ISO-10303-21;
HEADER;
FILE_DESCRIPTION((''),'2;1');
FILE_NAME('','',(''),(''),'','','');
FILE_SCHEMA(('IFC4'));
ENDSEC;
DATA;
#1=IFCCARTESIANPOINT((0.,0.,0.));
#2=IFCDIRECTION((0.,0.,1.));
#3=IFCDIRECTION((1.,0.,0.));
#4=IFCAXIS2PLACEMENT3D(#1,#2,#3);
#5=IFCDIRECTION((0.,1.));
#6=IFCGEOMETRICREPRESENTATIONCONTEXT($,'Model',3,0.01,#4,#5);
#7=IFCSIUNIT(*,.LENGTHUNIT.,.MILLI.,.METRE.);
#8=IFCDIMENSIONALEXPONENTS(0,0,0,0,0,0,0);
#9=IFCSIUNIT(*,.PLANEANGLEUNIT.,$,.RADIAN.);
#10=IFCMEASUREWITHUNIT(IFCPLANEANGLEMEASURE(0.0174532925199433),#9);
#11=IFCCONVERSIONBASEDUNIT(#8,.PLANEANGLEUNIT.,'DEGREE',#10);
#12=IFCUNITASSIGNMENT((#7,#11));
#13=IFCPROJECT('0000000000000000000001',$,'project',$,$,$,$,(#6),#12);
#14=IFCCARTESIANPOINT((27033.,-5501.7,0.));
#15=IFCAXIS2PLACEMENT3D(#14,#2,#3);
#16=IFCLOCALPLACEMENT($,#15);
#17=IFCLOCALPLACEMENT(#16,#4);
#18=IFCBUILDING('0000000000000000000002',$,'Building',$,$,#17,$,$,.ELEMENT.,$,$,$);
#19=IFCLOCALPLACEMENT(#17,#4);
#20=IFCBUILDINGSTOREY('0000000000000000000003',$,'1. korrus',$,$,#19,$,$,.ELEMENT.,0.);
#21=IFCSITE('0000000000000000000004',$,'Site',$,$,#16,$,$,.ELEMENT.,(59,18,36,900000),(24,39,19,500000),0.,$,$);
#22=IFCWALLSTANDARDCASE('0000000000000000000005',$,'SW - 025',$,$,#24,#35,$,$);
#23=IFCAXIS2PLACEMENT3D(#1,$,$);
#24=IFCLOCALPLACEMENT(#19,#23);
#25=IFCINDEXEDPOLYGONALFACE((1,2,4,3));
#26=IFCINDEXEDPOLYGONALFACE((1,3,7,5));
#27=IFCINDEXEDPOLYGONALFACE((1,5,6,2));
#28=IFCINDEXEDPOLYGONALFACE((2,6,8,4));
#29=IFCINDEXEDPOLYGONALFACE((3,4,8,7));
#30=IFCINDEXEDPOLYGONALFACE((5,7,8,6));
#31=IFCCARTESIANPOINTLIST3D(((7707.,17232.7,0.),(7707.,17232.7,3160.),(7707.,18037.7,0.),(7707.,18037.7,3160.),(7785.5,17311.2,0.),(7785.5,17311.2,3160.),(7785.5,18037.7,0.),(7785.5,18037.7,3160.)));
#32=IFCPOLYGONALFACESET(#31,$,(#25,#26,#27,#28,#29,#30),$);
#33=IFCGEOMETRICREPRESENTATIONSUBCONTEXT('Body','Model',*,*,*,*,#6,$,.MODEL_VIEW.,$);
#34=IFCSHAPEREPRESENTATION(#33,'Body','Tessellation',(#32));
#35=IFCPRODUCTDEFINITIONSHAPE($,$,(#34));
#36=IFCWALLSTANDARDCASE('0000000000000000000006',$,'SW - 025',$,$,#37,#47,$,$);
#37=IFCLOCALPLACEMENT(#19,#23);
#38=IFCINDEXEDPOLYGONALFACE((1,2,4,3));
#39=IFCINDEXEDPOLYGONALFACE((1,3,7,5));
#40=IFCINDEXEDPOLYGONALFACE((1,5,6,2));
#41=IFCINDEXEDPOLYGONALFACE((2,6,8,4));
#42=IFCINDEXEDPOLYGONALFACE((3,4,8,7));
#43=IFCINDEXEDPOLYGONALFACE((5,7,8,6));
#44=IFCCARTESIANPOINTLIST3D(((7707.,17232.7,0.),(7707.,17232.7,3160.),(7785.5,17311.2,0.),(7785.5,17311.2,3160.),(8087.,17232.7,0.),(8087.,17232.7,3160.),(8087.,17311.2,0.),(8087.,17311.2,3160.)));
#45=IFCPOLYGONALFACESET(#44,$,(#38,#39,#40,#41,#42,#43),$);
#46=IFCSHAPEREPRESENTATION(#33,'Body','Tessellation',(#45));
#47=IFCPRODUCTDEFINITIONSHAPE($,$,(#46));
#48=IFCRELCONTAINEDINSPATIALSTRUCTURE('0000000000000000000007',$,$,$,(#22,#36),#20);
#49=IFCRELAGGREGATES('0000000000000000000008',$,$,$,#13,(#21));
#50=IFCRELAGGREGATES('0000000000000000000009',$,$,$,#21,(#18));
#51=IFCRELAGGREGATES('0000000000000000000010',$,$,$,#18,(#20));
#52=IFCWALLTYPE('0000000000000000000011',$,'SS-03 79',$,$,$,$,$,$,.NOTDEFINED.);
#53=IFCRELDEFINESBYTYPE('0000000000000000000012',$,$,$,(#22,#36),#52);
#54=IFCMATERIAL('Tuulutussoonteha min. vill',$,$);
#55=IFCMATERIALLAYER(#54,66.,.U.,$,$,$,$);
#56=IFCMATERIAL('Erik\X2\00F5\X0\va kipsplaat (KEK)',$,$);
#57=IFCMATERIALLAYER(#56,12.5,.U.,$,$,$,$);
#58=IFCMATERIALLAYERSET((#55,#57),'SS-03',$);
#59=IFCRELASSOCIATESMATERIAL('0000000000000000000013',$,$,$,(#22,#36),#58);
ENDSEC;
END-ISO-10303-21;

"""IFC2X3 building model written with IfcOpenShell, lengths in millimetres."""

from ifc_helpers import new_model, entity, si_unit, converted_unit, direction, frame, origin_with_axes, place, context, subcontext, project, spatial, polyline, outline, extrude, material, layer, layer_set, layer_usage, type_object, element, save


model = new_model("IFC2X3")

# Units and contexts
model_context = context("Model", 3, precision=0.01, world=origin_with_axes(), true_north=direction((0.0, 1.0)))
body_context = subcontext(model_context, "Body", "Model", "MODEL_VIEW")
ifc_project = project(units=[si_unit("LENGTHUNIT", "METRE", prefix="MILLI"), converted_unit("PLANEANGLEUNIT", "DEGREE", entity("IfcPlaneAngleMeasure", 0.0174532925199433), si_unit("PLANEANGLEUNIT", "RADIAN"), dimensions=[0, 0, 0, 0, 0, 0, 0])], contexts=[model_context])

# Site, building, storey
site_placement = place(None, frame((27033.0, -5501.7, 0.0), z_axis=(0.0, 0.0, 1.0), x_axis=(1.0, 0.0, 0.0)))
site = spatial("IfcSite", under=ifc_project, at=site_placement, Name="Site", CompositionType="ELEMENT", RefLatitude=(59, 18, 36, 900000), RefLongitude=(24, 39, 19, 500000), RefElevation=0.0)
building_placement = place(site_placement, origin_with_axes())
building = spatial("IfcBuilding", under=site, at=building_placement, Name="Building", CompositionType="ELEMENT")
storey_placement = place(building_placement, origin_with_axes())
storey = spatial("IfcBuildingStorey", under=building, at=storey_placement, Name="1. korrus", CompositionType="ELEMENT", Elevation=0.0)

# Shared definitions
ifc_material_1 = material(Name="Erikõva kipsplaat (KEK)")
ifc_material_2 = material(Name="Tuulutussoonteha min. vill")

# Walls
ifc_layer_1 = layer(ifc_material_2, 66.0, ventilated="UNKNOWN")
ifc_layer_2 = layer(ifc_material_1, 12.5, ventilated="UNKNOWN")
ifc_layer_set_1 = layer_set([ifc_layer_1, ifc_layer_2], Name="SS-03")
ifc_layer_usage_1 = layer_usage(ifc_layer_set_1, "AXIS2", "POSITIVE", -78.5)
wall_type_1 = type_object("IfcWallType", Name="SS-03 79", PredefinedType="NOTDEFINED")
wall_1_placement = place(storey_placement, frame((7707.0, 17232.7, 0.0), z_axis=(0.0, 0.0, 1.0), x_axis=(0.0, 1.0, 0.0)))
element("IfcWallStandardCase", 1, at=wall_1_placement, inside=storey, type_object=wall_type_1, material=ifc_layer_usage_1, Name="SW - 025", context=body_context, shape_type="SweptSolid", body=[
    extrude(outline(polyline([(78.5, -78.5), (805.0, -78.5), (805.0, 0.0), (0.0, 0.0), (78.5, -78.5)])), origin_with_axes(), (0.0, 0.0, 1.0), 3160.0),
])
ifc_layer_usage_2 = layer_usage(ifc_layer_set_1, "AXIS2", "NEGATIVE", 78.5)
wall_2_placement = place(storey_placement, frame((7707.0, 17232.7, 0.0), z_axis=(0.0, 0.0, 1.0), x_axis=(1.0, 0.0, 0.0)))
element("IfcWallStandardCase", 2, at=wall_2_placement, inside=storey, type_object=wall_type_1, material=ifc_layer_usage_2, Name="SW - 025", context=body_context, shape_type="SweptSolid", body=[
    extrude(outline(polyline([(0.0, 0.0), (380.0, 0.0), (380.0, 78.5), (78.5, 78.5), (0.0, 0.0)])), origin_with_axes(), (0.0, 0.0, 1.0), 3160.0),
])

save(model, "model.ifc")
